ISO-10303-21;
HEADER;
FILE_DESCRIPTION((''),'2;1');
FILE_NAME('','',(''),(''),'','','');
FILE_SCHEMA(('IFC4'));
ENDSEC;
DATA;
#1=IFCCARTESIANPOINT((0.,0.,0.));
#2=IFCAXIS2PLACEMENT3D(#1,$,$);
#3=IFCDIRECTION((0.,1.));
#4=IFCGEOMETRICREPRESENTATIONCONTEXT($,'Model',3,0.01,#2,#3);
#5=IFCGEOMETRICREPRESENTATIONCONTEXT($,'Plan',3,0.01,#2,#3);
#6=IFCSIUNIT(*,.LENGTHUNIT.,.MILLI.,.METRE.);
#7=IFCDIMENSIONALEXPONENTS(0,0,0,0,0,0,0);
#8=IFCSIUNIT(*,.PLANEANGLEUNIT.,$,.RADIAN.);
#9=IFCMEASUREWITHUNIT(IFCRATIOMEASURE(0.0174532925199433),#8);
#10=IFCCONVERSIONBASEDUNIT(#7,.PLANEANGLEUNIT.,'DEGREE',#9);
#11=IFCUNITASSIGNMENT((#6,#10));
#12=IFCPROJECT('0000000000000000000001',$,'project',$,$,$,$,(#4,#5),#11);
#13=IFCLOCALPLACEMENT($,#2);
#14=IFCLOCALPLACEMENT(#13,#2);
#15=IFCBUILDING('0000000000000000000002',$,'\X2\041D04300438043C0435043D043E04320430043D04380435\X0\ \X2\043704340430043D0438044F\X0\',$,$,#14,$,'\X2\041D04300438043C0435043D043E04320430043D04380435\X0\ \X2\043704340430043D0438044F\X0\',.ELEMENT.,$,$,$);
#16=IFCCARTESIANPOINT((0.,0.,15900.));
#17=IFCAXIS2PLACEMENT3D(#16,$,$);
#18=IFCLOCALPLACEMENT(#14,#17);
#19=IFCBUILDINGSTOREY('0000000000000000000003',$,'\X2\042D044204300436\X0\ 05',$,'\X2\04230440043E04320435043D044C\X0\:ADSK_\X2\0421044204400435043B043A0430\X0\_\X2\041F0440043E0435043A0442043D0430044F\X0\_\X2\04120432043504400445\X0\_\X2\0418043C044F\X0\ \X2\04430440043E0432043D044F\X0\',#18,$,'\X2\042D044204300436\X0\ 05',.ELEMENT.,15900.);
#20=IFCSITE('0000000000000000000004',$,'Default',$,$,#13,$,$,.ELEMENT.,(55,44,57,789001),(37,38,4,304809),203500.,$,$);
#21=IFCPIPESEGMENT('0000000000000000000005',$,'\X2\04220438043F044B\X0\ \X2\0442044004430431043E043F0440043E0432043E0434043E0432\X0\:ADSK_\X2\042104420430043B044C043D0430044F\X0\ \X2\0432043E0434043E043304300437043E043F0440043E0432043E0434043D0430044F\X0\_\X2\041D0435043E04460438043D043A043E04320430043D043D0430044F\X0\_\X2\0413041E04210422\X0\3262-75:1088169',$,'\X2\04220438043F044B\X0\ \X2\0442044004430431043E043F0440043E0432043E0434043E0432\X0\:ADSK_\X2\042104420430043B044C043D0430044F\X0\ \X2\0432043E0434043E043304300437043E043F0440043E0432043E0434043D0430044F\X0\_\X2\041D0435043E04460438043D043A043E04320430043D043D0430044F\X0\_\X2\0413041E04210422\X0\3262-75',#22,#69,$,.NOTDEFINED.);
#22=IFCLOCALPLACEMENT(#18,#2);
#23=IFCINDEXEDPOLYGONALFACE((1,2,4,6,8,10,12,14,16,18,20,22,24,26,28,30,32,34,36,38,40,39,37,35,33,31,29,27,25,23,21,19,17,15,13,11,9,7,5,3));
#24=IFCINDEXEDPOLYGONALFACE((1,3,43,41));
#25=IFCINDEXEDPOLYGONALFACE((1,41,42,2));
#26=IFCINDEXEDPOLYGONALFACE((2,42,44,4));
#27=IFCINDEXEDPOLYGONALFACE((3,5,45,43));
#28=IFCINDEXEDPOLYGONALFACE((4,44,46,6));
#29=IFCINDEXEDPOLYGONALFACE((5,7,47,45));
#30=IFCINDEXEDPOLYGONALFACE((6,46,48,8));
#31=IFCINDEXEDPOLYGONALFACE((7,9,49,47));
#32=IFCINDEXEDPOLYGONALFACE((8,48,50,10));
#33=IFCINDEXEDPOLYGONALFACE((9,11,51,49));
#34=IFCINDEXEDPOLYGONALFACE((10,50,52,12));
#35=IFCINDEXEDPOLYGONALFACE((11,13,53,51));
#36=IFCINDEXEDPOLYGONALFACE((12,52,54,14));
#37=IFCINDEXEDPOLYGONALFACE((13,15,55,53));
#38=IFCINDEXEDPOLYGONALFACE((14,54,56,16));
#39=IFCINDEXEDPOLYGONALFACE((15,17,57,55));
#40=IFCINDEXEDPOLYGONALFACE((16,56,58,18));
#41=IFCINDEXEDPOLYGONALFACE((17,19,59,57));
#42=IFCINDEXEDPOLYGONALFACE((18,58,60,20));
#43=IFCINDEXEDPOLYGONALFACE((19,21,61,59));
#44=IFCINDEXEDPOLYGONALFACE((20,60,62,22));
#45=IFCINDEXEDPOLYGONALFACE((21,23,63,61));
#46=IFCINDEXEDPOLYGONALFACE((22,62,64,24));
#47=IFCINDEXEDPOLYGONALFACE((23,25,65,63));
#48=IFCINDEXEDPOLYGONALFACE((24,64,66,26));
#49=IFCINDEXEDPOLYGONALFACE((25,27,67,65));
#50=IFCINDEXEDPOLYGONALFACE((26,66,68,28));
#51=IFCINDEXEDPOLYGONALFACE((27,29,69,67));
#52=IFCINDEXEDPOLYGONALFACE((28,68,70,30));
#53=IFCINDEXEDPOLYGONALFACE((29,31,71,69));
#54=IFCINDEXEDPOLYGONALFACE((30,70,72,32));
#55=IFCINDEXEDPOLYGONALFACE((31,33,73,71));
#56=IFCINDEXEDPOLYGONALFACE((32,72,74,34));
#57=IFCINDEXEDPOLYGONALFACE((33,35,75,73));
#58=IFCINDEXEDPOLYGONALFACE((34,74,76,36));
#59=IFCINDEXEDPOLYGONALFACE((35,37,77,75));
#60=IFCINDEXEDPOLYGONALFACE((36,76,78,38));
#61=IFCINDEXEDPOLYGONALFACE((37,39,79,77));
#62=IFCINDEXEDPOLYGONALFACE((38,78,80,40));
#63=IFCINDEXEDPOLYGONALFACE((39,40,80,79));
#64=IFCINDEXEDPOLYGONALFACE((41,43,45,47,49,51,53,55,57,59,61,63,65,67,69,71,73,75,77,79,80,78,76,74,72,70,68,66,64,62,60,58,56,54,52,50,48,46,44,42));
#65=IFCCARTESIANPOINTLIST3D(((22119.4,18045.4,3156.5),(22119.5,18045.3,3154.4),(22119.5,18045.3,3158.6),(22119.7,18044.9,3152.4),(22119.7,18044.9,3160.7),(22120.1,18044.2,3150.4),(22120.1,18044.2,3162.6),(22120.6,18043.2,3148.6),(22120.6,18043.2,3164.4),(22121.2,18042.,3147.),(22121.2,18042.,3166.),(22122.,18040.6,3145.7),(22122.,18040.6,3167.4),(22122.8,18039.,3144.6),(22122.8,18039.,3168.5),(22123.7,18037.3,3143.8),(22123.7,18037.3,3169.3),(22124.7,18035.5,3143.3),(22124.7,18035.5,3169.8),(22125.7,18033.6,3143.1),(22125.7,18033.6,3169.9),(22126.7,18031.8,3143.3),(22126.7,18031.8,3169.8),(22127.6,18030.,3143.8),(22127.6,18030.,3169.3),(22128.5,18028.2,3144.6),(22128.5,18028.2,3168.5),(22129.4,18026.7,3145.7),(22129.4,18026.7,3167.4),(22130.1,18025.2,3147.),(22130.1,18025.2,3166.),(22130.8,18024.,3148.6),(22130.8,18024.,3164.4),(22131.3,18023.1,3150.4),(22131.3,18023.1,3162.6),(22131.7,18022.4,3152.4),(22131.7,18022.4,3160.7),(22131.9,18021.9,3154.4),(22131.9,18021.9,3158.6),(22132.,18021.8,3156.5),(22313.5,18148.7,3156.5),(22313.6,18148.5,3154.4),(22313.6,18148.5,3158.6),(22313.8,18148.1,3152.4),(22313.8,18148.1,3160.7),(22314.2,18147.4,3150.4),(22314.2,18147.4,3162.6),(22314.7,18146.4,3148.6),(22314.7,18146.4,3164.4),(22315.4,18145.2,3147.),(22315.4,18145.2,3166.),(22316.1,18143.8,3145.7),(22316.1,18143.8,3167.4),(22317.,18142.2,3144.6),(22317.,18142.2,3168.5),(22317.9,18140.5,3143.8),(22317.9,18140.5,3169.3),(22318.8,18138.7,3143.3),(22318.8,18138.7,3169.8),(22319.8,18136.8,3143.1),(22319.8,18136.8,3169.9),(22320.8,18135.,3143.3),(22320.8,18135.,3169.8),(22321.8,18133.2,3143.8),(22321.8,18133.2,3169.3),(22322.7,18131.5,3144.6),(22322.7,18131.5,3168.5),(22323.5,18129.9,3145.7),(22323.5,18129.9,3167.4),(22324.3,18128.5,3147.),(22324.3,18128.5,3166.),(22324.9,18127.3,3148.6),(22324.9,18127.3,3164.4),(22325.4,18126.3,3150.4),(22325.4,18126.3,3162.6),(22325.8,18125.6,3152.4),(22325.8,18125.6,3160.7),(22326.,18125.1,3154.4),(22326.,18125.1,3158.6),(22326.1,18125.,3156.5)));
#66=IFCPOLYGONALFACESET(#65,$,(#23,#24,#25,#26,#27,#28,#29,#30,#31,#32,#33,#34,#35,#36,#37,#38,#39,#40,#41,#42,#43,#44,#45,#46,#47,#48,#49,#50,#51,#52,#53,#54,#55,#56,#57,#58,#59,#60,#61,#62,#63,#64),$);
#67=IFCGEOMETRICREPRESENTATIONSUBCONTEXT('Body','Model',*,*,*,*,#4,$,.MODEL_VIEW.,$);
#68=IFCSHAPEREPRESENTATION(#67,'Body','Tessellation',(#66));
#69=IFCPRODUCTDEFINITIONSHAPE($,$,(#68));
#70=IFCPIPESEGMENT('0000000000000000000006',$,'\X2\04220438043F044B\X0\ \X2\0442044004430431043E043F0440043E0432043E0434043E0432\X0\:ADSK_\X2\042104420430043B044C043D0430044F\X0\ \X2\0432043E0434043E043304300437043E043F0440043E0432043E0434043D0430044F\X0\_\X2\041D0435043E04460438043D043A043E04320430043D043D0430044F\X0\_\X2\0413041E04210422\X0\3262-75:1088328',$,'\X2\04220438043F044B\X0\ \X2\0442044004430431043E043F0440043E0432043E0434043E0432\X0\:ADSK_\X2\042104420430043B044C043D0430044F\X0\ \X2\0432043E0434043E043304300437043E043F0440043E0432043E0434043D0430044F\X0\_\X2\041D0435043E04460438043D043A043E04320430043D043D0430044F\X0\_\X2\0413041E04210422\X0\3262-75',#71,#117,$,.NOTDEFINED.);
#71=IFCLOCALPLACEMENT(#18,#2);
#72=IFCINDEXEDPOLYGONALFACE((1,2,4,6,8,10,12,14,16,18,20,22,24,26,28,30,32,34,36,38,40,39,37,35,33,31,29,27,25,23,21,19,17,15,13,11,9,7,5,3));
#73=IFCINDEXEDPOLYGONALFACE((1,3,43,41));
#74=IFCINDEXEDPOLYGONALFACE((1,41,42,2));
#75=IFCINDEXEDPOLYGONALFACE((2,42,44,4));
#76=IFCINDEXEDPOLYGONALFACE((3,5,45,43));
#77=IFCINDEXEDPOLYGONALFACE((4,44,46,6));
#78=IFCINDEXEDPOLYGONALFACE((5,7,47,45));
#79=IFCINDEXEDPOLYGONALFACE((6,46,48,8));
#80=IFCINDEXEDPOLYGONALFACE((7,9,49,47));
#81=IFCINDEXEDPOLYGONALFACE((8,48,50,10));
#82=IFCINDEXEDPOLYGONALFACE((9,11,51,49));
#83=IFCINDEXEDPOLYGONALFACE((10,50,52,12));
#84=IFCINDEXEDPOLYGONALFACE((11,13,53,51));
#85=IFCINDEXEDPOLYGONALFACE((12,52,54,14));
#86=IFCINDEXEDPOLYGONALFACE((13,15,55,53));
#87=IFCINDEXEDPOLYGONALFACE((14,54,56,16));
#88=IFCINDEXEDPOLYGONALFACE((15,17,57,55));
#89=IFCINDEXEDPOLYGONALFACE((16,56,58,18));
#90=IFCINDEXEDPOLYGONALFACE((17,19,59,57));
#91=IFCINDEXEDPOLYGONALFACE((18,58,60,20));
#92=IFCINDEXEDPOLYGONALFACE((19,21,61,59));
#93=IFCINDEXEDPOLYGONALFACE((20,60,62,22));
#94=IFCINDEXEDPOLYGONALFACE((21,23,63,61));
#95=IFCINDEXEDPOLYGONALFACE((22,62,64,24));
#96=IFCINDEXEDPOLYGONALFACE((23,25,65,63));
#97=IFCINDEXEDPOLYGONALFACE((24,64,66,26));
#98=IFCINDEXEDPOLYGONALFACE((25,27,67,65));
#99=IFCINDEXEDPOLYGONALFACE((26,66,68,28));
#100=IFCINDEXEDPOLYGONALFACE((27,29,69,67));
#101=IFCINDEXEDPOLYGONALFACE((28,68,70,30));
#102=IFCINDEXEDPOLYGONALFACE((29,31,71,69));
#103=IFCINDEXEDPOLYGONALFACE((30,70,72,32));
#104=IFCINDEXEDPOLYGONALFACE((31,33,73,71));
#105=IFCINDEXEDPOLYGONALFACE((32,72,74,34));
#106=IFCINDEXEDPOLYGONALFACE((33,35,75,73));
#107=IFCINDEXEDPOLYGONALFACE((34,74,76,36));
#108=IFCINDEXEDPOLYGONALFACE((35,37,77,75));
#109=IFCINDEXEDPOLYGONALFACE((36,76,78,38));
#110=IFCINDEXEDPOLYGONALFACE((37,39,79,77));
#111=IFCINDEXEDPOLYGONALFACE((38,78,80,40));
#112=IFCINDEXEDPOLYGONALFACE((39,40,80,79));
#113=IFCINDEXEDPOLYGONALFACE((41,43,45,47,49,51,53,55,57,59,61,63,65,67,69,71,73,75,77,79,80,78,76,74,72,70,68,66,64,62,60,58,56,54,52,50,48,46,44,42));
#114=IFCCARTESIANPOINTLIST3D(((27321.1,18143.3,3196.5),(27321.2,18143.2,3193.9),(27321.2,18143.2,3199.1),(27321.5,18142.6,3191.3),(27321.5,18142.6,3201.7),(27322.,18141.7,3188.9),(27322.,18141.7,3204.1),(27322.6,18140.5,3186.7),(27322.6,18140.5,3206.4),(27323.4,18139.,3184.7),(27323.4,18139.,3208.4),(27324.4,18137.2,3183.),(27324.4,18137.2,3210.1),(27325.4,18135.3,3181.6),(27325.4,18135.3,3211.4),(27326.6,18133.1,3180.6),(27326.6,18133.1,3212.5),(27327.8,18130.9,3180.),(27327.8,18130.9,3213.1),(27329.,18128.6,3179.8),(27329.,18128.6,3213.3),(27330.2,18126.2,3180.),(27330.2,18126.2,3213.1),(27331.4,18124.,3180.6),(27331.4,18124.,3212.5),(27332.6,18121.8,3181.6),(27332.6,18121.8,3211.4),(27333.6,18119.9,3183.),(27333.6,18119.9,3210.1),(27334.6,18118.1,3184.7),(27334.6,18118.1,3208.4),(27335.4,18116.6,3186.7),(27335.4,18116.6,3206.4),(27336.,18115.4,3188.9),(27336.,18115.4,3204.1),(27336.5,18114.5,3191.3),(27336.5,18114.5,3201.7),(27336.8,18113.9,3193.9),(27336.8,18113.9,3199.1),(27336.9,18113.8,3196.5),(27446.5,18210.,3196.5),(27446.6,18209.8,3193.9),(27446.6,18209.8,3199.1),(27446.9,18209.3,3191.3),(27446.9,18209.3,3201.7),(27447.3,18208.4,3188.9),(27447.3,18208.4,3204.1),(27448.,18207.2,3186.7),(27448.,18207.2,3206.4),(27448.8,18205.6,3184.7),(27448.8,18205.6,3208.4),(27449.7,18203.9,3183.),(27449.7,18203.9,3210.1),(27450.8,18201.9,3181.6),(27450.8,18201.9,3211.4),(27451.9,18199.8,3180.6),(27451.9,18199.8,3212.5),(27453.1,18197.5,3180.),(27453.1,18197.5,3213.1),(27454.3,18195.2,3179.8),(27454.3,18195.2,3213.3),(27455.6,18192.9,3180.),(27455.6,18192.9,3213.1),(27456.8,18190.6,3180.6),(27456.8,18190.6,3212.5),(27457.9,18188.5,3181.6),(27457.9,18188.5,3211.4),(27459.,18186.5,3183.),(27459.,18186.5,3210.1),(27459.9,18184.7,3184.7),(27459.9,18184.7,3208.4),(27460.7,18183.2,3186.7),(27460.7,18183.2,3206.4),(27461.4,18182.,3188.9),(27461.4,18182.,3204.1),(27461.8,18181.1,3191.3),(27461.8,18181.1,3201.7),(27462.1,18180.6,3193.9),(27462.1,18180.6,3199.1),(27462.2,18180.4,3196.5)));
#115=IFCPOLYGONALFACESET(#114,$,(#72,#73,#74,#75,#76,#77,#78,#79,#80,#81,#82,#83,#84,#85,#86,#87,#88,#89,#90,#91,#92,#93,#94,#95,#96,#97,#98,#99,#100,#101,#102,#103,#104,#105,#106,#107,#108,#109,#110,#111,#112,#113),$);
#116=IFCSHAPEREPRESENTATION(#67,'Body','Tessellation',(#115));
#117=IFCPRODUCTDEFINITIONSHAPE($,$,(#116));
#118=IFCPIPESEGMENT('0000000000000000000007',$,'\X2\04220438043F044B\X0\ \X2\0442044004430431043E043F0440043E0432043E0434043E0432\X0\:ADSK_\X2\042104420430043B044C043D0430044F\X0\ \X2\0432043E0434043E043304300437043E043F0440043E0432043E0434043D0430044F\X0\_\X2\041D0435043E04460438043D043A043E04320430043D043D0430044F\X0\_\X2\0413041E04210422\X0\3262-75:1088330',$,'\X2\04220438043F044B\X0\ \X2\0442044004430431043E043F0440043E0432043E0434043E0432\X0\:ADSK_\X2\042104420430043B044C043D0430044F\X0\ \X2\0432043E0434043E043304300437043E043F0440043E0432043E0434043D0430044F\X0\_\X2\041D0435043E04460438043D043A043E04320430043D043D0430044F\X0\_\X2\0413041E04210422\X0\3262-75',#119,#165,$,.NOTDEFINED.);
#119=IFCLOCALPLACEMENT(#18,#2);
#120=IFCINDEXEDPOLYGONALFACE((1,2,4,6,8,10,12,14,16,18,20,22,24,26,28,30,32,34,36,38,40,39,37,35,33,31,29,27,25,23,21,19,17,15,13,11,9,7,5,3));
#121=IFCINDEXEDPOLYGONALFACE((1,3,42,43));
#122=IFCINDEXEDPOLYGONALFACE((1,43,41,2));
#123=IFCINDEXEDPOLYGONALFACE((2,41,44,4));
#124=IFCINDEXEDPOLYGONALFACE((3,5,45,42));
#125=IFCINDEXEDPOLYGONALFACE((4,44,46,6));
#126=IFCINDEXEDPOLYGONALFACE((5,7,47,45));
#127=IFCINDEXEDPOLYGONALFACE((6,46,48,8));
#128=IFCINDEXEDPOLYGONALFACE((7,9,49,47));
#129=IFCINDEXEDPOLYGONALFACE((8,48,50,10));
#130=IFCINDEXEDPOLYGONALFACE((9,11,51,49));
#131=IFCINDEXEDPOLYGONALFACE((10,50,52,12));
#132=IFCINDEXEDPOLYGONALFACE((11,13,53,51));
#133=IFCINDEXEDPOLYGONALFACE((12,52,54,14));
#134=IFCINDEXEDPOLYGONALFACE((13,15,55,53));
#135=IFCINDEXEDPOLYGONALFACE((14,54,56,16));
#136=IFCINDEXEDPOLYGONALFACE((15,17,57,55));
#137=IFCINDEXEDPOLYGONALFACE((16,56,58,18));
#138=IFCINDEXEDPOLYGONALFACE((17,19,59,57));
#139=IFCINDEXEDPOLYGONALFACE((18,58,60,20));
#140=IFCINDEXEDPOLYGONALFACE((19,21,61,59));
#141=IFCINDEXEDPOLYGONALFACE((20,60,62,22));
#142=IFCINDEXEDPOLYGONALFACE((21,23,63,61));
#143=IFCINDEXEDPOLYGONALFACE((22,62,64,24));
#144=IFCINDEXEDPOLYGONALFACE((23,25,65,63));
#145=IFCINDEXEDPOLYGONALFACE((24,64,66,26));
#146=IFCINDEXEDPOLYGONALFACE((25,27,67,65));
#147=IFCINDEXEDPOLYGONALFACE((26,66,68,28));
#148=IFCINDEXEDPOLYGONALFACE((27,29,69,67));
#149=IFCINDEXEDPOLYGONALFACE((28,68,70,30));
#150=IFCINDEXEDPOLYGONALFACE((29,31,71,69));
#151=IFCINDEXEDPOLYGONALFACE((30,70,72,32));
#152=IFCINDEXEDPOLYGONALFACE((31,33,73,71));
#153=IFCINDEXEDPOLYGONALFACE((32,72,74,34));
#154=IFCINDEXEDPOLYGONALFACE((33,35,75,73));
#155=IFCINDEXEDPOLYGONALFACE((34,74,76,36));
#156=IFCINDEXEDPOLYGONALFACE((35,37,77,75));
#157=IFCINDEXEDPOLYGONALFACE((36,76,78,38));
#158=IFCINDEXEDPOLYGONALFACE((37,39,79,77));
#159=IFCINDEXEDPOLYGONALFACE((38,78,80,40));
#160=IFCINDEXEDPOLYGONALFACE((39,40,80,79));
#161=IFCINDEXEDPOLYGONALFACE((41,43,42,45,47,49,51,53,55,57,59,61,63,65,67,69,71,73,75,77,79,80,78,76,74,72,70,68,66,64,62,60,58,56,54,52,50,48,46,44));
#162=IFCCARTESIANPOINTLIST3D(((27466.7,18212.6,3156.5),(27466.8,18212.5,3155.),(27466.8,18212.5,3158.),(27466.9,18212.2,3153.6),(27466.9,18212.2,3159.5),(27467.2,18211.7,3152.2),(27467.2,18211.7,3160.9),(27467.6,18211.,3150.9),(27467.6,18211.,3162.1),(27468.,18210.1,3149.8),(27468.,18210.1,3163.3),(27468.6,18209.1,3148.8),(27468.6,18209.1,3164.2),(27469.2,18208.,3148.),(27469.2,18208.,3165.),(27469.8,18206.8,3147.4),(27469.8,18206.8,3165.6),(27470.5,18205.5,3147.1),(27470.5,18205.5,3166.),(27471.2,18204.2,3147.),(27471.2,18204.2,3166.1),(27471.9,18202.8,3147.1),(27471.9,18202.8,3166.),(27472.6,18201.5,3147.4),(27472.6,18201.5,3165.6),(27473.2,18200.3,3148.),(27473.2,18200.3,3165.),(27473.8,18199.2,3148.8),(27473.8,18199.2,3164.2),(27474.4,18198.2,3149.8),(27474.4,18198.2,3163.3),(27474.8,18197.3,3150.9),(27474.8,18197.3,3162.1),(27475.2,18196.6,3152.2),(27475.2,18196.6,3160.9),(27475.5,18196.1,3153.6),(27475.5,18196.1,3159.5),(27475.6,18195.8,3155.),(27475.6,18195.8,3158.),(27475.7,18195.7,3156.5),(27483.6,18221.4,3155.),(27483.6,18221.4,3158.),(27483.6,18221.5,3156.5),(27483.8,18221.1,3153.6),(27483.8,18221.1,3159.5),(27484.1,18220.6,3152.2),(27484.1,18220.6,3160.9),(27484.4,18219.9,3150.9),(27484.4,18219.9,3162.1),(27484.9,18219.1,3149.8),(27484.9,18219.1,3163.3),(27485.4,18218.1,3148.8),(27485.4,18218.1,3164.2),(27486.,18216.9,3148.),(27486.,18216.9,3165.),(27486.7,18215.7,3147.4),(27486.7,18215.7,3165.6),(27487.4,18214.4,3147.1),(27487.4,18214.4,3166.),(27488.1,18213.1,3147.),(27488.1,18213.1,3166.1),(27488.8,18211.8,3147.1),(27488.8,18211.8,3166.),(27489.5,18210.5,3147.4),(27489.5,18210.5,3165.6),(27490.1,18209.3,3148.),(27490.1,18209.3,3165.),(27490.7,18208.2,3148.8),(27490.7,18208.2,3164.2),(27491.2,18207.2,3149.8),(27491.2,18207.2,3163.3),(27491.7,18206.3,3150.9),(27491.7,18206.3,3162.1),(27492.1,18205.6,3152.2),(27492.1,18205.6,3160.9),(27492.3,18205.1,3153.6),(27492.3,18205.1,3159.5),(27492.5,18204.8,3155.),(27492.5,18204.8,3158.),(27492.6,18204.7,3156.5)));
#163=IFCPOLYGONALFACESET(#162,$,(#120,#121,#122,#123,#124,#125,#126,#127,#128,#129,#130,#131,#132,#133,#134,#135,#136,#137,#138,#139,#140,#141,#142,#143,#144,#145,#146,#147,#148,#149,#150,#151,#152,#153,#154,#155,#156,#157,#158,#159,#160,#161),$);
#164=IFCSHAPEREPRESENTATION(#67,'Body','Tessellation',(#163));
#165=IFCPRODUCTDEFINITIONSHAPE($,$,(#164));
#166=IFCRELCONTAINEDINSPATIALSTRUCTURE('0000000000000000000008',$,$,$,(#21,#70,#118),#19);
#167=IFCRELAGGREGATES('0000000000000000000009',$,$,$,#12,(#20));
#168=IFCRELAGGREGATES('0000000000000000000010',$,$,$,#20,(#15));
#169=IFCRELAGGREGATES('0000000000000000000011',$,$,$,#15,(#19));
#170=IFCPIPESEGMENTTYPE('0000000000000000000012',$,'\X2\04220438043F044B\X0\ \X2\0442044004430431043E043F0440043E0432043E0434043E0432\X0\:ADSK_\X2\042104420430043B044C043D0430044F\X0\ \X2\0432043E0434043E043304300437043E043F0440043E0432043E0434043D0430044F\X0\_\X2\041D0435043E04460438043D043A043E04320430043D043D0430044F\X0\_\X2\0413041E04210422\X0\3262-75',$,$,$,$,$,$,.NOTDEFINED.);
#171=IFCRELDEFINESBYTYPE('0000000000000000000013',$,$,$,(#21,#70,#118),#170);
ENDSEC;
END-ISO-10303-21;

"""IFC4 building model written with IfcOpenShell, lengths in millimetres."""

from ifc_helpers import new_model, entity, si_unit, converted_unit, direction, frame, origin, place, context, subcontext, project, spatial, indexed_curve, outline, extrude, type_object, element, save


model = new_model("IFC4")

# Units and contexts
model_context = context("Model", 3, precision=0.01, world=origin(), true_north=direction((0.0, 1.0)))
plan_context = context("Plan", 3, precision=0.01, world=origin(), true_north=direction((0.0, 1.0)))
body_context = subcontext(model_context, "Body", "Model", "MODEL_VIEW")
ifc_project = project(units=[si_unit("LENGTHUNIT", "METRE", prefix="MILLI"), converted_unit("PLANEANGLEUNIT", "DEGREE", entity("IfcRatioMeasure", 0.0174532925199433), si_unit("PLANEANGLEUNIT", "RADIAN"), dimensions=[0, 0, 0, 0, 0, 0, 0])], contexts=[model_context, plan_context])

# Site, building, storey
site_placement = place(None, origin())
site = spatial("IfcSite", under=ifc_project, at=site_placement, Name="Default", CompositionType="ELEMENT", RefLatitude=(55, 44, 57, 789001), RefLongitude=(37, 38, 4, 304809), RefElevation=203500.0)
building_placement = place(site_placement, origin())
building = spatial("IfcBuilding", under=site, at=building_placement, Name="Наименование здания", LongName="Наименование здания", CompositionType="ELEMENT")
storey_placement = place(building_placement, frame((0.0, 0.0, 15900.0)))
storey = spatial("IfcBuildingStorey", under=building, at=storey_placement, Name="Этаж 05", ObjectType="Уровень:ADSK_Стрелка_Проектная_Вверх_Имя уровня", LongName="Этаж 05", CompositionType="ELEMENT", Elevation=15900.0)

# Pipe segments
placement = place(storey_placement, origin())
pipe_segment_type_1 = type_object("IfcPipeSegmentType", Name="Типы трубопроводов:ADSK_Стальная водогазопроводная_Неоцинкованная_ГОСТ3262-75", PredefinedType="NOTDEFINED")
element("IfcPipeSegment", 1, at=placement, inside=storey, type_object=pipe_segment_type_1, Name="Типы трубопроводов:ADSK_Стальная водогазопроводная_Неоцинкованная_ГОСТ3262-75:1088169", ObjectType="Типы трубопроводов:ADSK_Стальная водогазопроводная_Неоцинкованная_ГОСТ3262-75", PredefinedType="NOTDEFINED", context=body_context, shape_type="SweptSolid", body=[
    extrude(outline(indexed_curve([(13.4, 0.0), (13.2, 2.1), (12.7, 4.1), (11.9, 6.1), (10.8, 7.9), (9.5, 9.5), (7.9, 10.8), (6.1, 11.9), (4.1, 12.7), (2.1, 13.2), (0.0, 13.4), (-2.1, 13.2), (-4.1, 12.7), (-6.1, 11.9), (-7.9, 10.8), (-9.5, 9.5), (-10.8, 7.9), (-11.9, 6.1), (-12.7, 4.1), (-13.2, 2.1), (-13.4, 0.0), (-13.2, -2.1), (-12.7, -4.1), (-11.9, -6.1), (-10.8, -7.9), (-9.5, -9.5), (-7.9, -10.8), (-6.1, -11.9), (-4.1, -12.7), (-2.1, -13.2), (0.0, -13.4), (2.1, -13.2), (4.1, -12.7), (6.1, -11.9), (7.9, -10.8), (9.5, -9.5), (10.8, -7.9), (11.9, -6.1), (12.7, -4.1), (13.2, -2.1), (13.4, 0.0)], self_intersect=False)), frame((22125.7, 18033.6, 3156.5), z_axis=(0.882948, 0.469472, 0.0), x_axis=(0.469472, -0.882948, 0.0)), (0.0, 0.0, 1.0), 219.9),
])
element("IfcPipeSegment", 2, at=placement, inside=storey, type_object=pipe_segment_type_1, Name="Типы трубопроводов:ADSK_Стальная водогазопроводная_Неоцинкованная_ГОСТ3262-75:1088328", ObjectType="Типы трубопроводов:ADSK_Стальная водогазопроводная_Неоцинкованная_ГОСТ3262-75", PredefinedType="NOTDEFINED", context=body_context, shape_type="SweptSolid", body=[
    extrude(outline(indexed_curve([(16.8, 0.0), (16.5, 2.6), (15.9, 5.2), (14.9, 7.6), (13.6, 9.8), (11.8, 11.8), (9.8, 13.6), (7.6, 14.9), (5.2, 15.9), (2.6, 16.5), (0.0, 16.8), (-2.6, 16.5), (-5.2, 15.9), (-7.6, 14.9), (-9.8, 13.6), (-11.8, 11.8), (-13.6, 9.8), (-14.9, 7.6), (-15.9, 5.2), (-16.5, 2.6), (-16.8, 0.0), (-16.5, -2.6), (-15.9, -5.2), (-14.9, -7.6), (-13.6, -9.8), (-11.8, -11.8), (-9.8, -13.6), (-7.6, -14.9), (-5.2, -15.9), (-2.6, -16.5), (0.0, -16.8), (2.6, -16.5), (5.2, -15.9), (7.6, -14.9), (9.8, -13.6), (11.8, -11.8), (13.6, -9.8), (14.9, -7.6), (15.9, -5.2), (16.5, -2.6), (16.8, 0.0)], self_intersect=False)), frame((27329.0, 18128.5, 3196.5), z_axis=(0.882948, 0.469472, 0.0), x_axis=(0.469472, -0.882948, 0.0)), (0.0, 0.0, 1.0), 142.0),
])
element("IfcPipeSegment", 3, at=placement, inside=storey, type_object=pipe_segment_type_1, Name="Типы трубопроводов:ADSK_Стальная водогазопроводная_Неоцинкованная_ГОСТ3262-75:1088330", ObjectType="Типы трубопроводов:ADSK_Стальная водогазопроводная_Неоцинкованная_ГОСТ3262-75", PredefinedType="NOTDEFINED", context=body_context, shape_type="SweptSolid", body=[
    extrude(outline(indexed_curve([(9.5, 0.0), (9.4, 1.5), (9.1, 3.0), (8.5, 4.3), (7.7, 5.6), (6.8, 6.8), (5.6, 7.7), (4.3, 8.5), (3.0, 9.1), (1.5, 9.4), (0.0, 9.6), (-1.5, 9.4), (-3.0, 9.1), (-4.3, 8.5), (-5.6, 7.7), (-6.8, 6.8), (-7.7, 5.6), (-8.5, 4.3), (-9.1, 3.0), (-9.4, 1.5), (-9.5, 0.0), (-9.4, -1.5), (-9.1, -3.0), (-8.5, -4.3), (-7.7, -5.6), (-6.8, -6.8), (-5.6, -7.7), (-4.3, -8.5), (-3.0, -9.1), (-1.5, -9.4), (0.0, -9.6), (1.5, -9.4), (3.0, -9.1), (4.3, -8.5), (5.6, -7.7), (6.8, -6.8), (7.7, -5.6), (8.5, -4.3), (9.1, -3.0), (9.4, -1.5), (9.5, 0.0)], self_intersect=False)), frame((27471.2, 18204.2, 3156.5), z_axis=(0.882948, 0.469472, 0.0), x_axis=(-0.469472, 0.882948, 0.0)), (0.0, 0.0, 1.0), 19.1),
])

save(model, "model.ifc")
